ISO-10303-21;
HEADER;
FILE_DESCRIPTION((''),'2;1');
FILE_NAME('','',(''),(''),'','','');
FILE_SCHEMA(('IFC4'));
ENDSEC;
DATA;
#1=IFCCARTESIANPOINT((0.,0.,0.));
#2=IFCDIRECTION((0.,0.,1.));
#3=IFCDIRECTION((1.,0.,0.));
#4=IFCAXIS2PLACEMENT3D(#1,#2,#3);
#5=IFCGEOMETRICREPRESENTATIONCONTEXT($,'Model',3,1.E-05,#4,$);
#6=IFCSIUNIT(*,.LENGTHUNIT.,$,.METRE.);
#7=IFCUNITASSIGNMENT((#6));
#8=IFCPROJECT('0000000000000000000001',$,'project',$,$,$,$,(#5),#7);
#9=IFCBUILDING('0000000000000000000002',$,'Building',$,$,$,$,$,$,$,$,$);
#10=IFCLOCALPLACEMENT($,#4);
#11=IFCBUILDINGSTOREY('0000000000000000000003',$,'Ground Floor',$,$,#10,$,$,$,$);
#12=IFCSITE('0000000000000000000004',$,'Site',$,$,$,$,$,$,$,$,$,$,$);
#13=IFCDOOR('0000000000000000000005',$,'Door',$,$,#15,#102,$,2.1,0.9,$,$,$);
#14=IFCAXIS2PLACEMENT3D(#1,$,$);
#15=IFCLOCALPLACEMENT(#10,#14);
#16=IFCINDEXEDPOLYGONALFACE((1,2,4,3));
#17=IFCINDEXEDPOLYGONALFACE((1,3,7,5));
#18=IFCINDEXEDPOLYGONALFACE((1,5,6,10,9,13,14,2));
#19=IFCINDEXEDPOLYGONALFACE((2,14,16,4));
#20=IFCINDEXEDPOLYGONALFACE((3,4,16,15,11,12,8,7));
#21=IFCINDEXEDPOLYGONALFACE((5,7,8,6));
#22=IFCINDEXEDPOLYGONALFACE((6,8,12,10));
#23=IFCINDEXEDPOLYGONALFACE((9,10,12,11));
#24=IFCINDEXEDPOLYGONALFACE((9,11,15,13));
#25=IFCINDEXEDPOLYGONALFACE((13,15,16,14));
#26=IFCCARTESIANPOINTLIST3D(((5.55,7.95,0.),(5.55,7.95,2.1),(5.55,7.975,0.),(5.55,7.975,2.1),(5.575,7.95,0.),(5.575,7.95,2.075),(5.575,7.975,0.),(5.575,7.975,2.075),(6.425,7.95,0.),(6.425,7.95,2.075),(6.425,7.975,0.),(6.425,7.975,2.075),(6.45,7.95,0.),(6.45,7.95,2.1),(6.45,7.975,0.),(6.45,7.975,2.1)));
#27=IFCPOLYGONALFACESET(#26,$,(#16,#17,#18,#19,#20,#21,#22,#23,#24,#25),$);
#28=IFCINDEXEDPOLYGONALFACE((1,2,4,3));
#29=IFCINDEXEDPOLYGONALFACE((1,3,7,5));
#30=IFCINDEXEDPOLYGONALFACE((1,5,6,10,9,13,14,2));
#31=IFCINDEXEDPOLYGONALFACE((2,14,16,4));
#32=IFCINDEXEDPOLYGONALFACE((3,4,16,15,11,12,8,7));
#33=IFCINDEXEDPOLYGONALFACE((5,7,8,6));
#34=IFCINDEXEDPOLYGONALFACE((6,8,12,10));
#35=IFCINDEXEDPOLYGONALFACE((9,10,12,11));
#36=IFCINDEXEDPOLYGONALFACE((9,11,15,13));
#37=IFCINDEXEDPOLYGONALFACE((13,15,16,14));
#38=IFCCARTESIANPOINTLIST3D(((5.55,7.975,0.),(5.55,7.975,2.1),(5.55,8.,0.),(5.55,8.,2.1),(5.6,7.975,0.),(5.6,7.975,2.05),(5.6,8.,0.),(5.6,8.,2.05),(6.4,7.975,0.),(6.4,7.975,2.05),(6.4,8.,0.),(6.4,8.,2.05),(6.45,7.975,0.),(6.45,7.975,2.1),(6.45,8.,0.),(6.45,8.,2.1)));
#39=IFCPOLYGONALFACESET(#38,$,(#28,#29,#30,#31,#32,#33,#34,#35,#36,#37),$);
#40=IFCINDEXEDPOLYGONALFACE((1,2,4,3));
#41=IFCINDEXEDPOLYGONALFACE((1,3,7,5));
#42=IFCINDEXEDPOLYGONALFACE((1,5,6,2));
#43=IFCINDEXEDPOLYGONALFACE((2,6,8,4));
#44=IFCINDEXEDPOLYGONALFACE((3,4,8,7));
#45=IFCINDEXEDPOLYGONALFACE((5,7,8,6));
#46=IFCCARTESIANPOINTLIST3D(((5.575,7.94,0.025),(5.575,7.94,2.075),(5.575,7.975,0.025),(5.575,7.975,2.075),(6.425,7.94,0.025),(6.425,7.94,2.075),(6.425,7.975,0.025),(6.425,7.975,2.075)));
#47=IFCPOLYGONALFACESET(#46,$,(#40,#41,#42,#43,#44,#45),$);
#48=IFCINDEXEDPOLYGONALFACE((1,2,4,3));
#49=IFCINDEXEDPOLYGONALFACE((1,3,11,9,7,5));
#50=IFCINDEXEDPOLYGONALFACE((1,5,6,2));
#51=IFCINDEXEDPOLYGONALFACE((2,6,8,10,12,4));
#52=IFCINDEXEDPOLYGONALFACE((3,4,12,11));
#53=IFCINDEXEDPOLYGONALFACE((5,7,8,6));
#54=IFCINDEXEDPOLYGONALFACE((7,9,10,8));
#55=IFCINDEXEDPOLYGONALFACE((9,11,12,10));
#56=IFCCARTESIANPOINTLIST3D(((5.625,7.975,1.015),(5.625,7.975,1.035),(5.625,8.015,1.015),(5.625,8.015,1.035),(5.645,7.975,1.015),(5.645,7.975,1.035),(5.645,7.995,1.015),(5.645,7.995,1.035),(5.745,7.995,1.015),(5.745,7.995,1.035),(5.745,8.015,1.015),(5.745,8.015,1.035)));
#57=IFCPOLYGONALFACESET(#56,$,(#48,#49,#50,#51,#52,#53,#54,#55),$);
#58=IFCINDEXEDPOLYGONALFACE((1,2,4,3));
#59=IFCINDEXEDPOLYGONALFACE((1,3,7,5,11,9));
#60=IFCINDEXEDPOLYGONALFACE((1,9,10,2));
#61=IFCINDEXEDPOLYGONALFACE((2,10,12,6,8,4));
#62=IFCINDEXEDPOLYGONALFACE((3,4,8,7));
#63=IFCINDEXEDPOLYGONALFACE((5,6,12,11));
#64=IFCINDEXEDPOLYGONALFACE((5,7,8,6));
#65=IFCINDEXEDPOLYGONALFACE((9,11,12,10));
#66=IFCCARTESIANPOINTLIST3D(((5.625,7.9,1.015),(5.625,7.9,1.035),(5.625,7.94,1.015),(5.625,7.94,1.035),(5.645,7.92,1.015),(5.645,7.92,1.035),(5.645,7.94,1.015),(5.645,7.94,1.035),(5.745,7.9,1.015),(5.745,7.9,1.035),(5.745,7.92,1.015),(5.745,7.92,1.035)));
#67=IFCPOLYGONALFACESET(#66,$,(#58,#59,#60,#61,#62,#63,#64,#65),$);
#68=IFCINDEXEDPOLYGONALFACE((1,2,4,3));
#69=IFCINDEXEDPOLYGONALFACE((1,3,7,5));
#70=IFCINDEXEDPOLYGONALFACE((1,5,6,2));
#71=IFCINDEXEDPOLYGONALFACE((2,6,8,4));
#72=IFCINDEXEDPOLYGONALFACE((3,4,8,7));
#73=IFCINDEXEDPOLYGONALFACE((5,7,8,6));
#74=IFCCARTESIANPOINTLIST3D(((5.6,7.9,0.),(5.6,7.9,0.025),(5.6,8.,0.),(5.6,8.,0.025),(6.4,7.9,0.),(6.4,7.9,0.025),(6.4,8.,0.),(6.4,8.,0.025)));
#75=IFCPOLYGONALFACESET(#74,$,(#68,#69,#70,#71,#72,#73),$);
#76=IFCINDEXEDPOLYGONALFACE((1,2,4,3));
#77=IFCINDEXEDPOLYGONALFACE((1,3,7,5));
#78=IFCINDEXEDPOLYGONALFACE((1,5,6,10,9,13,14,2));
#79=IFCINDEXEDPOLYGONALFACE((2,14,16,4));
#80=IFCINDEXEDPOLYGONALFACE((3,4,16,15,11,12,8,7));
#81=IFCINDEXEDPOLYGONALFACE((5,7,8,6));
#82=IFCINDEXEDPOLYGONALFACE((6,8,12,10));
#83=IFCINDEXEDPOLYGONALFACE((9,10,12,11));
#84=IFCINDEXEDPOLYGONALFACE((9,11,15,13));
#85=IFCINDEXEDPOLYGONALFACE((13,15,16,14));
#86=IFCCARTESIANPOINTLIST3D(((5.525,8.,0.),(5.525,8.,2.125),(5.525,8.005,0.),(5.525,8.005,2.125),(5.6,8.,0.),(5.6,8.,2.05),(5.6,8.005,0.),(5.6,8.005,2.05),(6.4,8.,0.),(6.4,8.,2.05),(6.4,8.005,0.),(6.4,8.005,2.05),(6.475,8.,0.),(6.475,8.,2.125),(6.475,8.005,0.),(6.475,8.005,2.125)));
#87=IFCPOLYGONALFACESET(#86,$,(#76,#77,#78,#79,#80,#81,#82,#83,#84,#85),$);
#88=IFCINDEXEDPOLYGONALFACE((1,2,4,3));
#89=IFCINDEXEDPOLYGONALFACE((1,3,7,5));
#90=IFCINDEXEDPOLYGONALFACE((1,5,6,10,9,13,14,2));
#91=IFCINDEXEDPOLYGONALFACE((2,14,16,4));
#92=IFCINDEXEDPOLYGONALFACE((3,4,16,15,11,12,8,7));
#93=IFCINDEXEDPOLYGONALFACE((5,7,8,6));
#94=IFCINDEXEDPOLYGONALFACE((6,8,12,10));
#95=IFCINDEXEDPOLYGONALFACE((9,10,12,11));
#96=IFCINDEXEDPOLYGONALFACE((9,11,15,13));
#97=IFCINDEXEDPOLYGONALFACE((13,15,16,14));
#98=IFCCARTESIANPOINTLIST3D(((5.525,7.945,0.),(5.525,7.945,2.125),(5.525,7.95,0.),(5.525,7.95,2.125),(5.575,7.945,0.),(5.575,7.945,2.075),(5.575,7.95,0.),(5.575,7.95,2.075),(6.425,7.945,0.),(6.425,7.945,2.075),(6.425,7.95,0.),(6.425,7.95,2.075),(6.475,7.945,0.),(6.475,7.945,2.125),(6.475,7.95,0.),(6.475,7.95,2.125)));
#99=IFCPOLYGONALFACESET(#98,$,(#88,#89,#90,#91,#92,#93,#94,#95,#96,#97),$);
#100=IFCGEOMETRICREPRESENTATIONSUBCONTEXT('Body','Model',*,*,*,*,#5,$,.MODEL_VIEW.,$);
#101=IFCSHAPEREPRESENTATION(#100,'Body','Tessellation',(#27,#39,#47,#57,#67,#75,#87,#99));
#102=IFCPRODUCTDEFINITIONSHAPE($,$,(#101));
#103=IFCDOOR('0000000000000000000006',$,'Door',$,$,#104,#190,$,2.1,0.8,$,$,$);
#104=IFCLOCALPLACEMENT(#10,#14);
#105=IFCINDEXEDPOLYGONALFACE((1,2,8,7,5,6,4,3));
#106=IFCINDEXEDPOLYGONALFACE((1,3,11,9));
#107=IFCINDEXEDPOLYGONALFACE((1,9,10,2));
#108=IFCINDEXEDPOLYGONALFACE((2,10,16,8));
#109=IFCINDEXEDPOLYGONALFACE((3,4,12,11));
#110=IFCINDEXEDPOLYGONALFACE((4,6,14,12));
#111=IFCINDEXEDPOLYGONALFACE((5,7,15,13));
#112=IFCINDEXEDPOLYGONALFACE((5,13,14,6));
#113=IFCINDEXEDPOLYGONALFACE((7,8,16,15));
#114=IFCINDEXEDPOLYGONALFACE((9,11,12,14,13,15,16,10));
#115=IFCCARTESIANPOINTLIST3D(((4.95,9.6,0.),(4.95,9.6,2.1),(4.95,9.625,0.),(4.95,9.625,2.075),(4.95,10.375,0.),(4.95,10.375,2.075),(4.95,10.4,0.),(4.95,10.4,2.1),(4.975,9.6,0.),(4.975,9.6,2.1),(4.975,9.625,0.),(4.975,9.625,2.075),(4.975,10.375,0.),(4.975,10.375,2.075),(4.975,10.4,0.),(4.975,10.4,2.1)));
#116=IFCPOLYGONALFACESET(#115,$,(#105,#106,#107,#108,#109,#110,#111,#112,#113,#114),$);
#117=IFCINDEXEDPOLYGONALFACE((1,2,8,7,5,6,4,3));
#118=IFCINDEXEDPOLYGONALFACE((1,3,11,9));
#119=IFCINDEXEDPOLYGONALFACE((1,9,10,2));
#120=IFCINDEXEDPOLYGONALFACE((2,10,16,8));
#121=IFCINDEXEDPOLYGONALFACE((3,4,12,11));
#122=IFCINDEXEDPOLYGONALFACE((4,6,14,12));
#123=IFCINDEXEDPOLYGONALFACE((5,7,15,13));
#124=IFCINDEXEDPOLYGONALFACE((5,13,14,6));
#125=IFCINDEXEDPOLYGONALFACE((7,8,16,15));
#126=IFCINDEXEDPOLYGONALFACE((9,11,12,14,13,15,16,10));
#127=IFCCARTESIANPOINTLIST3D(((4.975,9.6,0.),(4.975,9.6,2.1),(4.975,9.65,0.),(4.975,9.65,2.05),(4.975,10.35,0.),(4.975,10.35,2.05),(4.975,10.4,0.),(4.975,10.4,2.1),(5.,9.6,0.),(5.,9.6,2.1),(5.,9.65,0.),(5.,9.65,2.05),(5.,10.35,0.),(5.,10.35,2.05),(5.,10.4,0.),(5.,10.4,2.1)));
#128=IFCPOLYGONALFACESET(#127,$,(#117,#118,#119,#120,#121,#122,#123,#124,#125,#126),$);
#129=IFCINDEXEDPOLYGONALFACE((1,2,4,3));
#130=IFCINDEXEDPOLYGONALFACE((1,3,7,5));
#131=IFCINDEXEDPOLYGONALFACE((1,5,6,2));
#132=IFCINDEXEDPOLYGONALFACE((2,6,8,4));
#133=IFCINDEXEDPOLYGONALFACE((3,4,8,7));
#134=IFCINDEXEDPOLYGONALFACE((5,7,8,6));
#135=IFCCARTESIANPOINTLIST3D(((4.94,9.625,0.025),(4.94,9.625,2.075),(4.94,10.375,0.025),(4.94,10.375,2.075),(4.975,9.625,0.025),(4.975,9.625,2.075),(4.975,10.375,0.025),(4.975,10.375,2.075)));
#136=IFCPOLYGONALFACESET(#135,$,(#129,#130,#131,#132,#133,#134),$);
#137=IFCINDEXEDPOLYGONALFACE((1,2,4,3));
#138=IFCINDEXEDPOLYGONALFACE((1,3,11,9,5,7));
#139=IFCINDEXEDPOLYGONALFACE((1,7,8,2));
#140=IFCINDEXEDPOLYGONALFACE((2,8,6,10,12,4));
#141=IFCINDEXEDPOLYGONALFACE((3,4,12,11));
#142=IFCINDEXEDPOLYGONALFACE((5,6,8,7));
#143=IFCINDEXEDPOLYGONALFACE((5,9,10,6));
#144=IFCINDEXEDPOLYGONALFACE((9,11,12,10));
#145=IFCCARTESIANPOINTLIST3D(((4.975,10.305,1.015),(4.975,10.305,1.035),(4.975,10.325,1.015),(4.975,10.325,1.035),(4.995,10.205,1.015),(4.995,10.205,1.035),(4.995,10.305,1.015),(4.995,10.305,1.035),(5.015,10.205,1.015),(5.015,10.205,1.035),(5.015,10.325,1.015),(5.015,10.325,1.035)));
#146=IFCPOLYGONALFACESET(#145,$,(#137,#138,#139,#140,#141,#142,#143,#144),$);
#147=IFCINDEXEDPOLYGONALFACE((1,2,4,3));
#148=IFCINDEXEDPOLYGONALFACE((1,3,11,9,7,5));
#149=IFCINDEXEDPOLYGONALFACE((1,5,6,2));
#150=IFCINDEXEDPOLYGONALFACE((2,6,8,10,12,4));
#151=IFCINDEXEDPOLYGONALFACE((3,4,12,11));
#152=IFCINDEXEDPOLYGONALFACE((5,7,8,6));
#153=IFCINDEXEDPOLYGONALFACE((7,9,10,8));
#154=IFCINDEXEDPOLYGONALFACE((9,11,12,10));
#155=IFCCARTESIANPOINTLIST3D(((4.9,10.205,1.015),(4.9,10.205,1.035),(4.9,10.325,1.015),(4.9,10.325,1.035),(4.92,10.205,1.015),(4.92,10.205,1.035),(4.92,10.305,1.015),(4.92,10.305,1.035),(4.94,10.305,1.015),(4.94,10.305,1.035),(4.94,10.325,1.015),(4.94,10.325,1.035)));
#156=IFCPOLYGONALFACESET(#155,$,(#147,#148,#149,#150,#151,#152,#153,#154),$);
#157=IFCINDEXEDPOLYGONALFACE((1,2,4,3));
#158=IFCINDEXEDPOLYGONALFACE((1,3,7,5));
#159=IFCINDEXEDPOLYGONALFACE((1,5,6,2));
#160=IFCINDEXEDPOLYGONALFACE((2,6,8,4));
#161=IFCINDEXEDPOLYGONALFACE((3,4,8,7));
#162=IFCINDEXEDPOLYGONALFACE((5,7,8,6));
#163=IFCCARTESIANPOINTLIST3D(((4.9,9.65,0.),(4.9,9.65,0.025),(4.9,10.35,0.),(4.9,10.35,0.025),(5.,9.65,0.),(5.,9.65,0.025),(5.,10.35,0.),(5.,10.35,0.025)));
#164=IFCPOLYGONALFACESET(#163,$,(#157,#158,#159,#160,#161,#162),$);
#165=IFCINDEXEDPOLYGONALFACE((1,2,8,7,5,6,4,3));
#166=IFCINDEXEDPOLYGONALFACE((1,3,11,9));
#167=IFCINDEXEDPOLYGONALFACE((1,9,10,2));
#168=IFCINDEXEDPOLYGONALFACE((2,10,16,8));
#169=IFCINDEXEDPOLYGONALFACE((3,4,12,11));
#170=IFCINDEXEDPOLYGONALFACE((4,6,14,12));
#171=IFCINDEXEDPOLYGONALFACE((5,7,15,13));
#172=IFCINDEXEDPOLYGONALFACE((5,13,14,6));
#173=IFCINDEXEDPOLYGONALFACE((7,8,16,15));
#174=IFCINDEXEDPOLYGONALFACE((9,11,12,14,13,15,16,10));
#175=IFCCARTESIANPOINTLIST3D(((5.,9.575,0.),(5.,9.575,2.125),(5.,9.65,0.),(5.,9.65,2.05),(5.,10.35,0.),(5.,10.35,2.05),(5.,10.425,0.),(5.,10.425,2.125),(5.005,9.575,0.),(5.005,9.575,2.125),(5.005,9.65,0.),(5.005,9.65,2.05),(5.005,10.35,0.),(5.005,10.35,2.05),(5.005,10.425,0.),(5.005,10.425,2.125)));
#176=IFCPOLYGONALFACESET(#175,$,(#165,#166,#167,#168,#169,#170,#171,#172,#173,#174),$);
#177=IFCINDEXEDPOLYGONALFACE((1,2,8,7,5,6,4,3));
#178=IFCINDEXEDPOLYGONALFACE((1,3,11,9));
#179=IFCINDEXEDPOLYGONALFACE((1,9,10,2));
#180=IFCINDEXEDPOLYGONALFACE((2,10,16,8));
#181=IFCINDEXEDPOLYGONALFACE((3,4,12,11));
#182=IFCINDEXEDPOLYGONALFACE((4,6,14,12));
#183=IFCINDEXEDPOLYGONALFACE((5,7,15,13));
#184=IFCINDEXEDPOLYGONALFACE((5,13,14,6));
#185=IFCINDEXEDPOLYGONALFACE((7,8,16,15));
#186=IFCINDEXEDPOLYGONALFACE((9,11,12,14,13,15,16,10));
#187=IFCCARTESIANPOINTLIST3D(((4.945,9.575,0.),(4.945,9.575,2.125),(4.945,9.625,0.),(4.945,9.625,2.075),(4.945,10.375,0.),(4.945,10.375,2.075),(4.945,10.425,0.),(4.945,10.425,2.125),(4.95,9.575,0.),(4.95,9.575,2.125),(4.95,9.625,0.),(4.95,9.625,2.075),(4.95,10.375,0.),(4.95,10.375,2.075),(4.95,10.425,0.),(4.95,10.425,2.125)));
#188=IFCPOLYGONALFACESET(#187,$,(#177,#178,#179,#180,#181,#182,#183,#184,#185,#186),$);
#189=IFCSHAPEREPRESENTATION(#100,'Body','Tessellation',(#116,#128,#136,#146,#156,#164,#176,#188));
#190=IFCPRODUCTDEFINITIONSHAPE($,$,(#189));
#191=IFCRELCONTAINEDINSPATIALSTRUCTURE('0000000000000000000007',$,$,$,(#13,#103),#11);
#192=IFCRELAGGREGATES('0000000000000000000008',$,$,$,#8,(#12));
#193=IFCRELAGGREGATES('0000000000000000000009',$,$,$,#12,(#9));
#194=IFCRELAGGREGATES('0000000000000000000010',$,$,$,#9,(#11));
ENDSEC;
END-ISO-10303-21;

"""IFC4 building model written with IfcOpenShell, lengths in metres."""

from ifc_helpers import new_model, si_unit, frame, origin_with_axes, place, context, subcontext, project, spatial, line, indexed_curve, outline, extrude, element, save


model = new_model("IFC4")

# Units and contexts
model_context = context("Model", 3, precision=1e-05, world=origin_with_axes())
body_context = subcontext(model_context, "Body", "Model", "MODEL_VIEW")
ifc_project = project(units=[si_unit("LENGTHUNIT", "METRE")], contexts=[model_context])

# Site, building, storey
site = spatial("IfcSite", under=ifc_project, Name="Site")
building = spatial("IfcBuilding", under=site, Name="Building")
storey_placement = place(None, origin_with_axes())
storey = spatial("IfcBuildingStorey", under=building, at=storey_placement, Name="Ground Floor")

# Doors
door_1_placement = place(storey_placement, frame((6.45, 8.0, 0.0), z_axis=(0.0, 0.0, 1.0), x_axis=(-1.0, 0.0, 0.0)))
element("IfcDoor", 1, at=door_1_placement, inside=storey, Name="Door", OverallHeight=2.1, OverallWidth=0.9, context=body_context, shape_type="SweptSolid", body=[
    extrude(outline(indexed_curve([(0.0, 0.0), (0.0, 2.1), (0.9, 2.1), (0.9, 0.0), (0.875, 0.0), (0.875, 2.075), (0.025, 2.075), (0.025, 0.0)], segments=[line(1, 2, 3, 4, 5, 6, 7, 8, 1)])), frame((0.0, 0.025, 0.0), z_axis=(0.0, -1.0, 0.0), x_axis=(1.0, 0.0, 0.0)), (0.0, 0.0, -1.0), 0.025),
    extrude(outline(indexed_curve([(0.0, 0.0), (0.0, 2.1), (0.9, 2.1), (0.9, 0.0), (0.85, 0.0), (0.85, 2.05), (0.05, 2.05), (0.05, 0.0)], segments=[line(1, 2, 3, 4, 5, 6, 7, 8, 1)])), frame((0.0, 0.0, 0.0), z_axis=(0.0, -1.0, 0.0), x_axis=(1.0, 0.0, 0.0)), (0.0, 0.0, -1.0), 0.025),
    extrude(outline(indexed_curve([(0.0, 0.0), (0.85, 0.0), (0.85, 0.035), (0.0, 0.035)], segments=[line(1, 2, 3, 4, 1)])), frame((0.025, 0.025, 0.025), z_axis=(0.0, 0.0, 1.0), x_axis=(1.0, 0.0, 0.0)), (0.0, 0.0, 1.0), 2.05),
    extrude(outline(indexed_curve([(0.0, 0.0), (0.0, -0.04), (-0.12, -0.04), (-0.12, -0.02), (-0.02, -0.02), (-0.02, 0.0)], segments=[line(1, 2, 3, 4, 5, 6, 1)])), frame((0.825, 0.025, 1.015), z_axis=(0.0, 0.0, 1.0), x_axis=(1.0, 0.0, 0.0)), (0.0, 0.0, 1.0), 0.02),
    extrude(outline(indexed_curve([(0.0, 0.0), (0.0, 0.04), (-0.12, 0.04), (-0.12, 0.02), (-0.02, 0.02), (-0.02, 0.0)], segments=[line(1, 2, 3, 4, 5, 6, 1)])), frame((0.825, 0.06, 1.015), z_axis=(0.0, 0.0, 1.0), x_axis=(1.0, 0.0, 0.0)), (0.0, 0.0, 1.0), 0.02),
    extrude(outline(indexed_curve([(0.0, 0.0), (0.8, 0.0), (0.8, 0.1), (0.0, 0.1)], segments=[line(1, 2, 3, 4, 1)])), frame((0.05, 0.0, 0.0), z_axis=(0.0, 0.0, 1.0), x_axis=(1.0, 0.0, 0.0)), (0.0, 0.0, 1.0), 0.025),
    extrude(outline(indexed_curve([(0.0, 0.0), (0.0, 2.125), (0.95, 2.125), (0.95, 0.0), (0.875, 0.0), (0.875, 2.05), (0.075, 2.05), (0.075, 0.0)], segments=[line(1, 2, 3, 4, 5, 6, 7, 8, 1)])), frame((-0.025, -0.005, 0.0), z_axis=(0.0, -1.0, 0.0), x_axis=(1.0, 0.0, 0.0)), (0.0, 0.0, -1.0), 0.005),
    extrude(outline(indexed_curve([(0.0, 0.0), (0.0, 2.125), (0.95, 2.125), (0.95, 0.0), (0.9, 0.0), (0.9, 2.075), (0.05, 2.075), (0.05, 0.0)], segments=[line(1, 2, 3, 4, 5, 6, 7, 8, 1)])), frame((-0.025, 0.05, 0.0), z_axis=(0.0, -1.0, 0.0), x_axis=(1.0, 0.0, 0.0)), (0.0, 0.0, -1.0), 0.005),
])
door_2_placement = place(storey_placement, frame((5.0, 9.6, 0.0), z_axis=(0.0, 0.0, 1.0), x_axis=(0.0, 1.0, 0.0)))
element("IfcDoor", 2, at=door_2_placement, inside=storey, Name="Door", OverallHeight=2.1, OverallWidth=0.8, context=body_context, shape_type="SweptSolid", body=[
    extrude(outline(indexed_curve([(0.0, 0.0), (0.0, 2.1), (0.8, 2.1), (0.8, 0.0), (0.775, 0.0), (0.775, 2.075), (0.025, 2.075), (0.025, 0.0)], segments=[line(1, 2, 3, 4, 5, 6, 7, 8, 1)])), frame((0.0, 0.025, 0.0), z_axis=(0.0, -1.0, 0.0), x_axis=(1.0, 0.0, 0.0)), (0.0, 0.0, -1.0), 0.025),
    extrude(outline(indexed_curve([(0.0, 0.0), (0.0, 2.1), (0.8, 2.1), (0.8, 0.0), (0.75, 0.0), (0.75, 2.05), (0.05, 2.05), (0.05, 0.0)], segments=[line(1, 2, 3, 4, 5, 6, 7, 8, 1)])), frame((0.0, 0.0, 0.0), z_axis=(0.0, -1.0, 0.0), x_axis=(1.0, 0.0, 0.0)), (0.0, 0.0, -1.0), 0.025),
    extrude(outline(indexed_curve([(0.0, 0.0), (0.75, 0.0), (0.75, 0.035), (0.0, 0.035)], segments=[line(1, 2, 3, 4, 1)])), frame((0.025, 0.025, 0.025), z_axis=(0.0, 0.0, 1.0), x_axis=(1.0, 0.0, 0.0)), (0.0, 0.0, 1.0), 2.05),
    extrude(outline(indexed_curve([(0.0, 0.0), (0.0, -0.04), (-0.12, -0.04), (-0.12, -0.02), (-0.02, -0.02), (-0.02, 0.0)], segments=[line(1, 2, 3, 4, 5, 6, 1)])), frame((0.725, 0.025, 1.015), z_axis=(0.0, 0.0, 1.0), x_axis=(1.0, 0.0, 0.0)), (0.0, 0.0, 1.0), 0.02),
    extrude(outline(indexed_curve([(0.0, 0.0), (0.0, 0.04), (-0.12, 0.04), (-0.12, 0.02), (-0.02, 0.02), (-0.02, 0.0)], segments=[line(1, 2, 3, 4, 5, 6, 1)])), frame((0.725, 0.06, 1.015), z_axis=(0.0, 0.0, 1.0), x_axis=(1.0, 0.0, 0.0)), (0.0, 0.0, 1.0), 0.02),
    extrude(outline(indexed_curve([(0.0, 0.0), (0.7, 0.0), (0.7, 0.1), (0.0, 0.1)], segments=[line(1, 2, 3, 4, 1)])), frame((0.05, 0.0, 0.0), z_axis=(0.0, 0.0, 1.0), x_axis=(1.0, 0.0, 0.0)), (0.0, 0.0, 1.0), 0.025),
    extrude(outline(indexed_curve([(0.0, 0.0), (0.0, 2.125), (0.85, 2.125), (0.85, 0.0), (0.775, 0.0), (0.775, 2.05), (0.075, 2.05), (0.075, 0.0)], segments=[line(1, 2, 3, 4, 5, 6, 7, 8, 1)])), frame((-0.025, -0.005, 0.0), z_axis=(0.0, -1.0, 0.0), x_axis=(1.0, 0.0, 0.0)), (0.0, 0.0, -1.0), 0.005),
    extrude(outline(indexed_curve([(0.0, 0.0), (0.0, 2.125), (0.85, 2.125), (0.85, 0.0), (0.8, 0.0), (0.8, 2.075), (0.05, 2.075), (0.05, 0.0)], segments=[line(1, 2, 3, 4, 5, 6, 7, 8, 1)])), frame((-0.025, 0.05, 0.0), z_axis=(0.0, -1.0, 0.0), x_axis=(1.0, 0.0, 0.0)), (0.0, 0.0, -1.0), 0.005),
])

save(model, "model.ifc")
